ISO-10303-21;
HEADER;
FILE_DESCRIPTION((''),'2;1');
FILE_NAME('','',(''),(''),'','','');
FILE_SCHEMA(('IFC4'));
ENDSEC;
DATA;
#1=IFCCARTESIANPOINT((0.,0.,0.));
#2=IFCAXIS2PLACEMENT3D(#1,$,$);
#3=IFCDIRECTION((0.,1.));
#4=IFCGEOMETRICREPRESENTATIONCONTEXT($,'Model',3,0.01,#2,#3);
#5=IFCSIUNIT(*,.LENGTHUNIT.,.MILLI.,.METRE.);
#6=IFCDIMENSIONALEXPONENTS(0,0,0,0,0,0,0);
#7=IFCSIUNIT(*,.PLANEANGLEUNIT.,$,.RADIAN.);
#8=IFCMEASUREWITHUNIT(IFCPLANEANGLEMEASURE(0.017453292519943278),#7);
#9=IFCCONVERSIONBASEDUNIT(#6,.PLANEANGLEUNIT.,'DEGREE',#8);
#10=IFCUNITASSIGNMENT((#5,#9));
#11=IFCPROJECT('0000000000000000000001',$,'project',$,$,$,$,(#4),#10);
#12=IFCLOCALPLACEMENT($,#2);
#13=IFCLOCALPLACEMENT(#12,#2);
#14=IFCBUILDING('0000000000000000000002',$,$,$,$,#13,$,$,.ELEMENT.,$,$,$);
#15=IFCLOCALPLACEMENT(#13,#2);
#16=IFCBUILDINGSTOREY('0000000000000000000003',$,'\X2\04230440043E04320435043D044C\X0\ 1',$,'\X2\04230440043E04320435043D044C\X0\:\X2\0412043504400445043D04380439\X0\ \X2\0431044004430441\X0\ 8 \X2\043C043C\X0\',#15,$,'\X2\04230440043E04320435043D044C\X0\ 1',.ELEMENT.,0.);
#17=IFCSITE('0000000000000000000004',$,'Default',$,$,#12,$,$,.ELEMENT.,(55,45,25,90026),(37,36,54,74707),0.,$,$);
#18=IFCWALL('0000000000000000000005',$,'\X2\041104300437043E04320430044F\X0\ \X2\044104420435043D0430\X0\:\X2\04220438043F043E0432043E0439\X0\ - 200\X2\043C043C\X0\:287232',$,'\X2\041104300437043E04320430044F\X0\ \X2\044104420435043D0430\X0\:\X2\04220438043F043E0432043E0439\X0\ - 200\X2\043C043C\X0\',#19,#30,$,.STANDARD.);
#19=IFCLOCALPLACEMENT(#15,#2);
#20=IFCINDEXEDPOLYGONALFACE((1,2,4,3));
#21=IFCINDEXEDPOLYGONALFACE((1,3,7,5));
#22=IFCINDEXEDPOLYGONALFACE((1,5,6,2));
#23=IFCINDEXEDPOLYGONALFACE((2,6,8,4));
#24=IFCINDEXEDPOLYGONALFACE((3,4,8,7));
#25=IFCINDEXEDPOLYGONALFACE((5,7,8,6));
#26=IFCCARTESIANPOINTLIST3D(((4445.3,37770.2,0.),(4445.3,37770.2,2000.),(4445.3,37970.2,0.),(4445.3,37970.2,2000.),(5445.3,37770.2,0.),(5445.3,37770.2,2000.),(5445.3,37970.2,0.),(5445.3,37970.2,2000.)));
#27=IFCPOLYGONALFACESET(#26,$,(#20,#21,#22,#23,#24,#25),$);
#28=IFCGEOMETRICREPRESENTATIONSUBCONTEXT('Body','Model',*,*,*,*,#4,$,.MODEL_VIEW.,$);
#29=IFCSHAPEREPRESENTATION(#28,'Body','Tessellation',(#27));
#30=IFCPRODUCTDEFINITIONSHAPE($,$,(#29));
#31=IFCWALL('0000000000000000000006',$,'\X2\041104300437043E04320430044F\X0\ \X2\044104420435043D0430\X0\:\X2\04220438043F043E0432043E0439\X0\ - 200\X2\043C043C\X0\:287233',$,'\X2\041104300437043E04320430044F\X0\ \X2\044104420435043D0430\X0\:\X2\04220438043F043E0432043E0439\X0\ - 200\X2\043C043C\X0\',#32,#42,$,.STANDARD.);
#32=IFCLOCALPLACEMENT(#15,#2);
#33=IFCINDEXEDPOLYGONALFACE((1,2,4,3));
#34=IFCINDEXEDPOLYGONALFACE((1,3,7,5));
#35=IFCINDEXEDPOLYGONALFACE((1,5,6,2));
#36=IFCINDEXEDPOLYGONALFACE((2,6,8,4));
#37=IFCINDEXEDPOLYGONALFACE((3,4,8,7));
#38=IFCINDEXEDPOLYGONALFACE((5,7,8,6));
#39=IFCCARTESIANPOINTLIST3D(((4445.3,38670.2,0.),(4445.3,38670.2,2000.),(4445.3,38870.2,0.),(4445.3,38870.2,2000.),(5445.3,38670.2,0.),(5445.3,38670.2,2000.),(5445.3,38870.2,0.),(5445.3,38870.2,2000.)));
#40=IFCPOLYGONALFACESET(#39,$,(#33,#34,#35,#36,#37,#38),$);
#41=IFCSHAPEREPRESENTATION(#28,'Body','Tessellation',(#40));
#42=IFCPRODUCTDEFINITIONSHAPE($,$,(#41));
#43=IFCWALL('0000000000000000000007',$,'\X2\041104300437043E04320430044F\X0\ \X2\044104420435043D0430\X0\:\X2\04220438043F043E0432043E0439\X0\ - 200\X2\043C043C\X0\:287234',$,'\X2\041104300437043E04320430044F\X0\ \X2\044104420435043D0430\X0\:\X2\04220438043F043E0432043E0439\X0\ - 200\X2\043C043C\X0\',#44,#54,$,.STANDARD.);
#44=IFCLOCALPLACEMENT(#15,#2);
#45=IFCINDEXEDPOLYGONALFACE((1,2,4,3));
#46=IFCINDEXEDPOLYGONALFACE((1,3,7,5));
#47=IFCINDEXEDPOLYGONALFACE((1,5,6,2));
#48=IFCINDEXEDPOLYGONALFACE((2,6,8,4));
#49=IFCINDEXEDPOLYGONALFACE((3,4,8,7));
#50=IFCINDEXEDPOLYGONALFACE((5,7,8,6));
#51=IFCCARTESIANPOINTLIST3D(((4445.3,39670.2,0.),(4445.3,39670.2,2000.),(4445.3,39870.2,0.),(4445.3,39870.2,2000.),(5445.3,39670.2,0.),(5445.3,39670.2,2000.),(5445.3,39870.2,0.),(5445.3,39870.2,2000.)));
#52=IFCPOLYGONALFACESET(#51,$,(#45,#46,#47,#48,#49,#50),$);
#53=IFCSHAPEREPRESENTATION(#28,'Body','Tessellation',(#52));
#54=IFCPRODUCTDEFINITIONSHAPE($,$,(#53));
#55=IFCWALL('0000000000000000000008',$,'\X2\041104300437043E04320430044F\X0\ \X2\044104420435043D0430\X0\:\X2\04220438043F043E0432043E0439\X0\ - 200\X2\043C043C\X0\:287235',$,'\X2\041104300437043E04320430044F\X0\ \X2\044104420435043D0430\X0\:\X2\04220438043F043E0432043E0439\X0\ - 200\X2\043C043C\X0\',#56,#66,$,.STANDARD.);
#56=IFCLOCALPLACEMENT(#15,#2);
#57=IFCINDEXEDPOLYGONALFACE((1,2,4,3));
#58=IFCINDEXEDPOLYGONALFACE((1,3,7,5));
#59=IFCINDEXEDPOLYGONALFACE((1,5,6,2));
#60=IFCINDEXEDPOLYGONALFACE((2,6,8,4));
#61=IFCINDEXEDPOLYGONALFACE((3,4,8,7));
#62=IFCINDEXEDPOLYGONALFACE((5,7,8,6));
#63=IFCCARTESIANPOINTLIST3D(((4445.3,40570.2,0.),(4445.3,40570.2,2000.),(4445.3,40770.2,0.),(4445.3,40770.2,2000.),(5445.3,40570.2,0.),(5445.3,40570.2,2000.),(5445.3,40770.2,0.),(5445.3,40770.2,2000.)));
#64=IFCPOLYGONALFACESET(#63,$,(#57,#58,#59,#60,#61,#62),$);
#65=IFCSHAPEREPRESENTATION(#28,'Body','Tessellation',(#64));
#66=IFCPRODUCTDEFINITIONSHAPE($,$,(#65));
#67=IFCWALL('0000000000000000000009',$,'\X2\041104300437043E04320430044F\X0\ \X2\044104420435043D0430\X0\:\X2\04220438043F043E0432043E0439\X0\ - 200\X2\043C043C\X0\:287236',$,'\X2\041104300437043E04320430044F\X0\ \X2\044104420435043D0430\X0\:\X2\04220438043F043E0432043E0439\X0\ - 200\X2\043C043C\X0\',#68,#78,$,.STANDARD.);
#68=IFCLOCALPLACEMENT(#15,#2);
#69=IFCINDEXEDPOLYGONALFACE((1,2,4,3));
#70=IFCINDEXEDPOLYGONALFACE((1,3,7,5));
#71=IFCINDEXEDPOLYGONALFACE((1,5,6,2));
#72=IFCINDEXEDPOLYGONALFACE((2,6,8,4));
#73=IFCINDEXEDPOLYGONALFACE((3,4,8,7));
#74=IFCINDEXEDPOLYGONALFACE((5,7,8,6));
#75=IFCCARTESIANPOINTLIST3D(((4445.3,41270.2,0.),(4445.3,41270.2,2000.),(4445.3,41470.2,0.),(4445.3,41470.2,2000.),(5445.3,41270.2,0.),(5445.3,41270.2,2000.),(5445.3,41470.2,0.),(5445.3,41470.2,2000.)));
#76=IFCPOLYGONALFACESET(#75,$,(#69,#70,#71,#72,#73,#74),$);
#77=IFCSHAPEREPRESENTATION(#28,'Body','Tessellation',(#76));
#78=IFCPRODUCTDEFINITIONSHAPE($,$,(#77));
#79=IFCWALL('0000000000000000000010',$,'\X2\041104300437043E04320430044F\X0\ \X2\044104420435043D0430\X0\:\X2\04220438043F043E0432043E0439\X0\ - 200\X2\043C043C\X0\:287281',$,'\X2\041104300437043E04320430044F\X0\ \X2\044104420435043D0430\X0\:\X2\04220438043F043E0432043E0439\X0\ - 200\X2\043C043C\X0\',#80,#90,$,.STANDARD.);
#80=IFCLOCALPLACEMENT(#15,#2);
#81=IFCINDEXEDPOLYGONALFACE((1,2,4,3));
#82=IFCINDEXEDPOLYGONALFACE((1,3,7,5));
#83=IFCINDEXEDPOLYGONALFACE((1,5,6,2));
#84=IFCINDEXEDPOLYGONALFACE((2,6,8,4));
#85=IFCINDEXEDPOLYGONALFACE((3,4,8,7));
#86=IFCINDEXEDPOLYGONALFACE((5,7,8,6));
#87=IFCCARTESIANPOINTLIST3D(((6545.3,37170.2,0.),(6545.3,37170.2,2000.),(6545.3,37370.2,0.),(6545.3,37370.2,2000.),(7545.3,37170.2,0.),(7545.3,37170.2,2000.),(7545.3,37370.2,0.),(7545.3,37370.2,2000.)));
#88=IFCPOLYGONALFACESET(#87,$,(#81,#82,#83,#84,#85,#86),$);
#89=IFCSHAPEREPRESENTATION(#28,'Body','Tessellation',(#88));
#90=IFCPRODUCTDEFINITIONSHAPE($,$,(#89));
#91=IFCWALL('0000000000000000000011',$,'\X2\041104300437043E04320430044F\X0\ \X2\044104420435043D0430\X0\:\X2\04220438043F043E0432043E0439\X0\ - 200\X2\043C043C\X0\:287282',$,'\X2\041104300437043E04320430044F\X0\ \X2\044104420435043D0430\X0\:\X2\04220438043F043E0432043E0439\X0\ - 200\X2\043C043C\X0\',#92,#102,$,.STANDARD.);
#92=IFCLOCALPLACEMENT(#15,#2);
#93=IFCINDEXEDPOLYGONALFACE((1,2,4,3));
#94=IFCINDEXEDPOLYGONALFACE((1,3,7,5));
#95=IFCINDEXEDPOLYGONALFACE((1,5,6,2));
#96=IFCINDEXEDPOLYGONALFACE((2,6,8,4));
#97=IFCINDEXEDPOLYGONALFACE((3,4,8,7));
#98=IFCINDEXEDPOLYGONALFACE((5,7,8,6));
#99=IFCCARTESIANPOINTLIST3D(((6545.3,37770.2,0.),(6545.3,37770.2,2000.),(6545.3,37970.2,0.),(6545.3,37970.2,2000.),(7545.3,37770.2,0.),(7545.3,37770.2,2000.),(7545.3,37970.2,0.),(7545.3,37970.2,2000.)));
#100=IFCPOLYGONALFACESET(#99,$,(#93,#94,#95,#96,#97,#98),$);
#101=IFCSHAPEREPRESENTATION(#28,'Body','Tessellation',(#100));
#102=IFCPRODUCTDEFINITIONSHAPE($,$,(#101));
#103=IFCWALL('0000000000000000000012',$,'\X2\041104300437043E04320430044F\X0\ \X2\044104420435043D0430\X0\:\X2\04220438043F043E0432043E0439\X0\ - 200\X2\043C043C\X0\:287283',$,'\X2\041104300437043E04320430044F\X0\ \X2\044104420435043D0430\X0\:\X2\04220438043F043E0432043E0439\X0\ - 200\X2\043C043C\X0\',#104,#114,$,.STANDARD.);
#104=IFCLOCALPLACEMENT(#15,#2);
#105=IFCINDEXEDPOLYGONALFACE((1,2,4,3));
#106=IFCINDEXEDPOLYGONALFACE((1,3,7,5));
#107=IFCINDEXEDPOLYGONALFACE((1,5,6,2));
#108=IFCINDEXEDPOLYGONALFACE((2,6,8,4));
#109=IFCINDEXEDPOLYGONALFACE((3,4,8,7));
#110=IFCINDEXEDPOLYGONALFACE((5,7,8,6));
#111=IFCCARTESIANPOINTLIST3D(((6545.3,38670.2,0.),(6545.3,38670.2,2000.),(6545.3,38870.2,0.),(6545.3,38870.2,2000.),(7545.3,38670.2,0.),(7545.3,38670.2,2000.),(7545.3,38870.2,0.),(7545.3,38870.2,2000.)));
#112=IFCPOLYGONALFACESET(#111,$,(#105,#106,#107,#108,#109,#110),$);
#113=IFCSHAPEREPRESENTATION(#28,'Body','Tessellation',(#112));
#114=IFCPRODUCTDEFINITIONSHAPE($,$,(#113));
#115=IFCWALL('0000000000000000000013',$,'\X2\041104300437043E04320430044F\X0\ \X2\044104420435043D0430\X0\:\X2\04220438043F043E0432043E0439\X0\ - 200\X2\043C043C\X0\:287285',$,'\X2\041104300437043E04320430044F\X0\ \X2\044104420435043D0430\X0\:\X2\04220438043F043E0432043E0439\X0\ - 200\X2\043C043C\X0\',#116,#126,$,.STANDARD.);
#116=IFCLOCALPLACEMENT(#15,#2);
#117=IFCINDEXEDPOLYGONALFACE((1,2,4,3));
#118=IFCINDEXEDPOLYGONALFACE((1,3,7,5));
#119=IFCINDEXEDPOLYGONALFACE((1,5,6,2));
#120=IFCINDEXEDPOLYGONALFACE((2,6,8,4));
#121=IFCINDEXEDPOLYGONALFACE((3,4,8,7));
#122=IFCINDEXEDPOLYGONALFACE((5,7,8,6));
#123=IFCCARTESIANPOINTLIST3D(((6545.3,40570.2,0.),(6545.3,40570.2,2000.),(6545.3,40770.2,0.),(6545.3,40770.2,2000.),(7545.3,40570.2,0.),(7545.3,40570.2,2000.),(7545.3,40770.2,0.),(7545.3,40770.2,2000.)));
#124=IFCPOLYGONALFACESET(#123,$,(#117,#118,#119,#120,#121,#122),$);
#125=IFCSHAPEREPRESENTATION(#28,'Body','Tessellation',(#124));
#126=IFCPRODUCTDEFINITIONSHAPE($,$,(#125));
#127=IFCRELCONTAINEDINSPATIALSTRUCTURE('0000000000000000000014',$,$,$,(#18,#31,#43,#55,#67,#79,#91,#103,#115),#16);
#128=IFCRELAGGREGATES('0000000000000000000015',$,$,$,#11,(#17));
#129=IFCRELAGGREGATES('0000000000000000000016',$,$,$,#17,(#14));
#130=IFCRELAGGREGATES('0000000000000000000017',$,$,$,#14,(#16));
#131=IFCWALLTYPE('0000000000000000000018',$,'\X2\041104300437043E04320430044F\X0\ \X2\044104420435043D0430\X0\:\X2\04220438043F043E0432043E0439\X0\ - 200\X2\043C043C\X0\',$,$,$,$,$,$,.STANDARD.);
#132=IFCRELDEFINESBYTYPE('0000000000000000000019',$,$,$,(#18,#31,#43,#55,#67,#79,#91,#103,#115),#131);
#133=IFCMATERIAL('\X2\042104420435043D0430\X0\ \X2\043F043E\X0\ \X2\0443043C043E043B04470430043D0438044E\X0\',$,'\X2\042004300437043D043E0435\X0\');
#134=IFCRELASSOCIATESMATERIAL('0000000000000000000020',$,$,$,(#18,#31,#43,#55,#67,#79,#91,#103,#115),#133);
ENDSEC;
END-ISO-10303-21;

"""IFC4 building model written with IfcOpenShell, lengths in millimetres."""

from ifc_helpers import new_model, entity, si_unit, converted_unit, direction, frame, origin, place, context, subcontext, project, spatial, indexed_curve, outline, extrude, material, type_object, element, save


model = new_model("IFC4")

# Units and contexts
model_context = context("Model", 3, precision=0.01, world=origin(), true_north=direction((0.0, 1.0)))
body_context = subcontext(model_context, "Body", "Model", "MODEL_VIEW")
ifc_project = project(units=[si_unit("LENGTHUNIT", "METRE", prefix="MILLI"), converted_unit("PLANEANGLEUNIT", "DEGREE", entity("IfcPlaneAngleMeasure", 0.017453292519943278), si_unit("PLANEANGLEUNIT", "RADIAN"), dimensions=[0, 0, 0, 0, 0, 0, 0])], contexts=[model_context])

# Site, building, storey
site_placement = place(None, origin())
site = spatial("IfcSite", under=ifc_project, at=site_placement, Name="Default", CompositionType="ELEMENT", RefLatitude=(55, 45, 25, 90026), RefLongitude=(37, 36, 54, 74707), RefElevation=0.0)
building_placement = place(site_placement, origin())
building = spatial("IfcBuilding", under=site, at=building_placement, CompositionType="ELEMENT")
storey_placement = place(building_placement, origin())
storey = spatial("IfcBuildingStorey", under=building, at=storey_placement, Name="Уровень 1", ObjectType="Уровень:Верхний брус 8 мм", LongName="Уровень 1", CompositionType="ELEMENT", Elevation=0.0)

# Walls
ifc_material = material(Name="Стена по умолчанию", Category="Разное")
wall_type = type_object("IfcWallType", Name="Базовая стена:Типовой - 200мм", PredefinedType="STANDARD")
for number, where, name in (
    (1, (4445.3, 37870.2, 0.0), "Базовая стена:Типовой - 200мм:287232"),
    (2, (4445.3, 38770.2, 0.0), "Базовая стена:Типовой - 200мм:287233"),
):
    element("IfcWall", number, at=place(storey_placement, frame(where)), inside=storey, type_object=wall_type, material=ifc_material, Name=name, ObjectType="Базовая стена:Типовой - 200мм", PredefinedType="STANDARD", context=body_context, shape_type="SweptSolid", body=[
        extrude(outline(indexed_curve([(1000.0, 100.0), (0.0, 100.0), (0.0, -100.0), (1000.0, -100.0), (1000.0, 100.0)], self_intersect=False)), origin(), (0.0, 0.0, 1.0), 2000.0),
    ])
wall_1_placement = place(storey_placement, frame((4445.3, 39770.2, 0.0)))
element("IfcWall", 3, at=wall_1_placement, inside=storey, type_object=wall_type, material=ifc_material, Name="Базовая стена:Типовой - 200мм:287234", ObjectType="Базовая стена:Типовой - 200мм", PredefinedType="STANDARD", context=body_context, shape_type="SweptSolid", body=[
    extrude(outline(indexed_curve([(1000.0, 100.0), (0.0, 100.0), (0.0, -100.0), (1000.0, -100.0), (1000.0, 100.0)], self_intersect=False)), origin(), (0.0, 0.0, 1.0), 2000.0),
])
for number, where, name in (
    (4, (4445.3, 40670.2, 0.0), "Базовая стена:Типовой - 200мм:287235"),
    (5, (4445.3, 41370.2, 0.0), "Базовая стена:Типовой - 200мм:287236"),
):
    element("IfcWall", number, at=place(storey_placement, frame(where)), inside=storey, type_object=wall_type, material=ifc_material, Name=name, ObjectType="Базовая стена:Типовой - 200мм", PredefinedType="STANDARD", context=body_context, shape_type="SweptSolid", body=[
        extrude(outline(indexed_curve([(1000.0, 100.0), (0.0, 100.0), (0.0, -100.0), (1000.0, -100.0), (1000.0, 100.0)], self_intersect=False)), origin(), (0.0, 0.0, 1.0), 2000.0),
    ])
wall_2_placement = place(storey_placement, frame((6545.3, 37270.2, 0.0)))
element("IfcWall", 6, at=wall_2_placement, inside=storey, type_object=wall_type, material=ifc_material, Name="Базовая стена:Типовой - 200мм:287281", ObjectType="Базовая стена:Типовой - 200мм", PredefinedType="STANDARD", context=body_context, shape_type="SweptSolid", body=[
    extrude(outline(indexed_curve([(1000.0, 100.0), (0.0, 100.0), (0.0, -100.0), (1000.0, -100.0), (1000.0, 100.0)], self_intersect=False)), origin(), (0.0, 0.0, 1.0), 2000.0),
])
for number, where, name in (
    (7, (6545.3, 37870.2, 0.0), "Базовая стена:Типовой - 200мм:287282"),
    (8, (6545.3, 38770.2, 0.0), "Базовая стена:Типовой - 200мм:287283"),
):
    element("IfcWall", number, at=place(storey_placement, frame(where)), inside=storey, type_object=wall_type, material=ifc_material, Name=name, ObjectType="Базовая стена:Типовой - 200мм", PredefinedType="STANDARD", context=body_context, shape_type="SweptSolid", body=[
        extrude(outline(indexed_curve([(1000.0, 100.0), (0.0, 100.0), (0.0, -100.0), (1000.0, -100.0), (1000.0, 100.0)], self_intersect=False)), origin(), (0.0, 0.0, 1.0), 2000.0),
    ])
wall_3_placement = place(storey_placement, frame((6545.3, 40670.2, 0.0)))
element("IfcWall", 9, at=wall_3_placement, inside=storey, type_object=wall_type, material=ifc_material, Name="Базовая стена:Типовой - 200мм:287285", ObjectType="Базовая стена:Типовой - 200мм", PredefinedType="STANDARD", context=body_context, shape_type="SweptSolid", body=[
    extrude(outline(indexed_curve([(1000.0, 100.0), (0.0, 100.0), (0.0, -100.0), (1000.0, -100.0), (1000.0, 100.0)], self_intersect=False)), origin(), (0.0, 0.0, 1.0), 2000.0),
])

save(model, "model.ifc")
